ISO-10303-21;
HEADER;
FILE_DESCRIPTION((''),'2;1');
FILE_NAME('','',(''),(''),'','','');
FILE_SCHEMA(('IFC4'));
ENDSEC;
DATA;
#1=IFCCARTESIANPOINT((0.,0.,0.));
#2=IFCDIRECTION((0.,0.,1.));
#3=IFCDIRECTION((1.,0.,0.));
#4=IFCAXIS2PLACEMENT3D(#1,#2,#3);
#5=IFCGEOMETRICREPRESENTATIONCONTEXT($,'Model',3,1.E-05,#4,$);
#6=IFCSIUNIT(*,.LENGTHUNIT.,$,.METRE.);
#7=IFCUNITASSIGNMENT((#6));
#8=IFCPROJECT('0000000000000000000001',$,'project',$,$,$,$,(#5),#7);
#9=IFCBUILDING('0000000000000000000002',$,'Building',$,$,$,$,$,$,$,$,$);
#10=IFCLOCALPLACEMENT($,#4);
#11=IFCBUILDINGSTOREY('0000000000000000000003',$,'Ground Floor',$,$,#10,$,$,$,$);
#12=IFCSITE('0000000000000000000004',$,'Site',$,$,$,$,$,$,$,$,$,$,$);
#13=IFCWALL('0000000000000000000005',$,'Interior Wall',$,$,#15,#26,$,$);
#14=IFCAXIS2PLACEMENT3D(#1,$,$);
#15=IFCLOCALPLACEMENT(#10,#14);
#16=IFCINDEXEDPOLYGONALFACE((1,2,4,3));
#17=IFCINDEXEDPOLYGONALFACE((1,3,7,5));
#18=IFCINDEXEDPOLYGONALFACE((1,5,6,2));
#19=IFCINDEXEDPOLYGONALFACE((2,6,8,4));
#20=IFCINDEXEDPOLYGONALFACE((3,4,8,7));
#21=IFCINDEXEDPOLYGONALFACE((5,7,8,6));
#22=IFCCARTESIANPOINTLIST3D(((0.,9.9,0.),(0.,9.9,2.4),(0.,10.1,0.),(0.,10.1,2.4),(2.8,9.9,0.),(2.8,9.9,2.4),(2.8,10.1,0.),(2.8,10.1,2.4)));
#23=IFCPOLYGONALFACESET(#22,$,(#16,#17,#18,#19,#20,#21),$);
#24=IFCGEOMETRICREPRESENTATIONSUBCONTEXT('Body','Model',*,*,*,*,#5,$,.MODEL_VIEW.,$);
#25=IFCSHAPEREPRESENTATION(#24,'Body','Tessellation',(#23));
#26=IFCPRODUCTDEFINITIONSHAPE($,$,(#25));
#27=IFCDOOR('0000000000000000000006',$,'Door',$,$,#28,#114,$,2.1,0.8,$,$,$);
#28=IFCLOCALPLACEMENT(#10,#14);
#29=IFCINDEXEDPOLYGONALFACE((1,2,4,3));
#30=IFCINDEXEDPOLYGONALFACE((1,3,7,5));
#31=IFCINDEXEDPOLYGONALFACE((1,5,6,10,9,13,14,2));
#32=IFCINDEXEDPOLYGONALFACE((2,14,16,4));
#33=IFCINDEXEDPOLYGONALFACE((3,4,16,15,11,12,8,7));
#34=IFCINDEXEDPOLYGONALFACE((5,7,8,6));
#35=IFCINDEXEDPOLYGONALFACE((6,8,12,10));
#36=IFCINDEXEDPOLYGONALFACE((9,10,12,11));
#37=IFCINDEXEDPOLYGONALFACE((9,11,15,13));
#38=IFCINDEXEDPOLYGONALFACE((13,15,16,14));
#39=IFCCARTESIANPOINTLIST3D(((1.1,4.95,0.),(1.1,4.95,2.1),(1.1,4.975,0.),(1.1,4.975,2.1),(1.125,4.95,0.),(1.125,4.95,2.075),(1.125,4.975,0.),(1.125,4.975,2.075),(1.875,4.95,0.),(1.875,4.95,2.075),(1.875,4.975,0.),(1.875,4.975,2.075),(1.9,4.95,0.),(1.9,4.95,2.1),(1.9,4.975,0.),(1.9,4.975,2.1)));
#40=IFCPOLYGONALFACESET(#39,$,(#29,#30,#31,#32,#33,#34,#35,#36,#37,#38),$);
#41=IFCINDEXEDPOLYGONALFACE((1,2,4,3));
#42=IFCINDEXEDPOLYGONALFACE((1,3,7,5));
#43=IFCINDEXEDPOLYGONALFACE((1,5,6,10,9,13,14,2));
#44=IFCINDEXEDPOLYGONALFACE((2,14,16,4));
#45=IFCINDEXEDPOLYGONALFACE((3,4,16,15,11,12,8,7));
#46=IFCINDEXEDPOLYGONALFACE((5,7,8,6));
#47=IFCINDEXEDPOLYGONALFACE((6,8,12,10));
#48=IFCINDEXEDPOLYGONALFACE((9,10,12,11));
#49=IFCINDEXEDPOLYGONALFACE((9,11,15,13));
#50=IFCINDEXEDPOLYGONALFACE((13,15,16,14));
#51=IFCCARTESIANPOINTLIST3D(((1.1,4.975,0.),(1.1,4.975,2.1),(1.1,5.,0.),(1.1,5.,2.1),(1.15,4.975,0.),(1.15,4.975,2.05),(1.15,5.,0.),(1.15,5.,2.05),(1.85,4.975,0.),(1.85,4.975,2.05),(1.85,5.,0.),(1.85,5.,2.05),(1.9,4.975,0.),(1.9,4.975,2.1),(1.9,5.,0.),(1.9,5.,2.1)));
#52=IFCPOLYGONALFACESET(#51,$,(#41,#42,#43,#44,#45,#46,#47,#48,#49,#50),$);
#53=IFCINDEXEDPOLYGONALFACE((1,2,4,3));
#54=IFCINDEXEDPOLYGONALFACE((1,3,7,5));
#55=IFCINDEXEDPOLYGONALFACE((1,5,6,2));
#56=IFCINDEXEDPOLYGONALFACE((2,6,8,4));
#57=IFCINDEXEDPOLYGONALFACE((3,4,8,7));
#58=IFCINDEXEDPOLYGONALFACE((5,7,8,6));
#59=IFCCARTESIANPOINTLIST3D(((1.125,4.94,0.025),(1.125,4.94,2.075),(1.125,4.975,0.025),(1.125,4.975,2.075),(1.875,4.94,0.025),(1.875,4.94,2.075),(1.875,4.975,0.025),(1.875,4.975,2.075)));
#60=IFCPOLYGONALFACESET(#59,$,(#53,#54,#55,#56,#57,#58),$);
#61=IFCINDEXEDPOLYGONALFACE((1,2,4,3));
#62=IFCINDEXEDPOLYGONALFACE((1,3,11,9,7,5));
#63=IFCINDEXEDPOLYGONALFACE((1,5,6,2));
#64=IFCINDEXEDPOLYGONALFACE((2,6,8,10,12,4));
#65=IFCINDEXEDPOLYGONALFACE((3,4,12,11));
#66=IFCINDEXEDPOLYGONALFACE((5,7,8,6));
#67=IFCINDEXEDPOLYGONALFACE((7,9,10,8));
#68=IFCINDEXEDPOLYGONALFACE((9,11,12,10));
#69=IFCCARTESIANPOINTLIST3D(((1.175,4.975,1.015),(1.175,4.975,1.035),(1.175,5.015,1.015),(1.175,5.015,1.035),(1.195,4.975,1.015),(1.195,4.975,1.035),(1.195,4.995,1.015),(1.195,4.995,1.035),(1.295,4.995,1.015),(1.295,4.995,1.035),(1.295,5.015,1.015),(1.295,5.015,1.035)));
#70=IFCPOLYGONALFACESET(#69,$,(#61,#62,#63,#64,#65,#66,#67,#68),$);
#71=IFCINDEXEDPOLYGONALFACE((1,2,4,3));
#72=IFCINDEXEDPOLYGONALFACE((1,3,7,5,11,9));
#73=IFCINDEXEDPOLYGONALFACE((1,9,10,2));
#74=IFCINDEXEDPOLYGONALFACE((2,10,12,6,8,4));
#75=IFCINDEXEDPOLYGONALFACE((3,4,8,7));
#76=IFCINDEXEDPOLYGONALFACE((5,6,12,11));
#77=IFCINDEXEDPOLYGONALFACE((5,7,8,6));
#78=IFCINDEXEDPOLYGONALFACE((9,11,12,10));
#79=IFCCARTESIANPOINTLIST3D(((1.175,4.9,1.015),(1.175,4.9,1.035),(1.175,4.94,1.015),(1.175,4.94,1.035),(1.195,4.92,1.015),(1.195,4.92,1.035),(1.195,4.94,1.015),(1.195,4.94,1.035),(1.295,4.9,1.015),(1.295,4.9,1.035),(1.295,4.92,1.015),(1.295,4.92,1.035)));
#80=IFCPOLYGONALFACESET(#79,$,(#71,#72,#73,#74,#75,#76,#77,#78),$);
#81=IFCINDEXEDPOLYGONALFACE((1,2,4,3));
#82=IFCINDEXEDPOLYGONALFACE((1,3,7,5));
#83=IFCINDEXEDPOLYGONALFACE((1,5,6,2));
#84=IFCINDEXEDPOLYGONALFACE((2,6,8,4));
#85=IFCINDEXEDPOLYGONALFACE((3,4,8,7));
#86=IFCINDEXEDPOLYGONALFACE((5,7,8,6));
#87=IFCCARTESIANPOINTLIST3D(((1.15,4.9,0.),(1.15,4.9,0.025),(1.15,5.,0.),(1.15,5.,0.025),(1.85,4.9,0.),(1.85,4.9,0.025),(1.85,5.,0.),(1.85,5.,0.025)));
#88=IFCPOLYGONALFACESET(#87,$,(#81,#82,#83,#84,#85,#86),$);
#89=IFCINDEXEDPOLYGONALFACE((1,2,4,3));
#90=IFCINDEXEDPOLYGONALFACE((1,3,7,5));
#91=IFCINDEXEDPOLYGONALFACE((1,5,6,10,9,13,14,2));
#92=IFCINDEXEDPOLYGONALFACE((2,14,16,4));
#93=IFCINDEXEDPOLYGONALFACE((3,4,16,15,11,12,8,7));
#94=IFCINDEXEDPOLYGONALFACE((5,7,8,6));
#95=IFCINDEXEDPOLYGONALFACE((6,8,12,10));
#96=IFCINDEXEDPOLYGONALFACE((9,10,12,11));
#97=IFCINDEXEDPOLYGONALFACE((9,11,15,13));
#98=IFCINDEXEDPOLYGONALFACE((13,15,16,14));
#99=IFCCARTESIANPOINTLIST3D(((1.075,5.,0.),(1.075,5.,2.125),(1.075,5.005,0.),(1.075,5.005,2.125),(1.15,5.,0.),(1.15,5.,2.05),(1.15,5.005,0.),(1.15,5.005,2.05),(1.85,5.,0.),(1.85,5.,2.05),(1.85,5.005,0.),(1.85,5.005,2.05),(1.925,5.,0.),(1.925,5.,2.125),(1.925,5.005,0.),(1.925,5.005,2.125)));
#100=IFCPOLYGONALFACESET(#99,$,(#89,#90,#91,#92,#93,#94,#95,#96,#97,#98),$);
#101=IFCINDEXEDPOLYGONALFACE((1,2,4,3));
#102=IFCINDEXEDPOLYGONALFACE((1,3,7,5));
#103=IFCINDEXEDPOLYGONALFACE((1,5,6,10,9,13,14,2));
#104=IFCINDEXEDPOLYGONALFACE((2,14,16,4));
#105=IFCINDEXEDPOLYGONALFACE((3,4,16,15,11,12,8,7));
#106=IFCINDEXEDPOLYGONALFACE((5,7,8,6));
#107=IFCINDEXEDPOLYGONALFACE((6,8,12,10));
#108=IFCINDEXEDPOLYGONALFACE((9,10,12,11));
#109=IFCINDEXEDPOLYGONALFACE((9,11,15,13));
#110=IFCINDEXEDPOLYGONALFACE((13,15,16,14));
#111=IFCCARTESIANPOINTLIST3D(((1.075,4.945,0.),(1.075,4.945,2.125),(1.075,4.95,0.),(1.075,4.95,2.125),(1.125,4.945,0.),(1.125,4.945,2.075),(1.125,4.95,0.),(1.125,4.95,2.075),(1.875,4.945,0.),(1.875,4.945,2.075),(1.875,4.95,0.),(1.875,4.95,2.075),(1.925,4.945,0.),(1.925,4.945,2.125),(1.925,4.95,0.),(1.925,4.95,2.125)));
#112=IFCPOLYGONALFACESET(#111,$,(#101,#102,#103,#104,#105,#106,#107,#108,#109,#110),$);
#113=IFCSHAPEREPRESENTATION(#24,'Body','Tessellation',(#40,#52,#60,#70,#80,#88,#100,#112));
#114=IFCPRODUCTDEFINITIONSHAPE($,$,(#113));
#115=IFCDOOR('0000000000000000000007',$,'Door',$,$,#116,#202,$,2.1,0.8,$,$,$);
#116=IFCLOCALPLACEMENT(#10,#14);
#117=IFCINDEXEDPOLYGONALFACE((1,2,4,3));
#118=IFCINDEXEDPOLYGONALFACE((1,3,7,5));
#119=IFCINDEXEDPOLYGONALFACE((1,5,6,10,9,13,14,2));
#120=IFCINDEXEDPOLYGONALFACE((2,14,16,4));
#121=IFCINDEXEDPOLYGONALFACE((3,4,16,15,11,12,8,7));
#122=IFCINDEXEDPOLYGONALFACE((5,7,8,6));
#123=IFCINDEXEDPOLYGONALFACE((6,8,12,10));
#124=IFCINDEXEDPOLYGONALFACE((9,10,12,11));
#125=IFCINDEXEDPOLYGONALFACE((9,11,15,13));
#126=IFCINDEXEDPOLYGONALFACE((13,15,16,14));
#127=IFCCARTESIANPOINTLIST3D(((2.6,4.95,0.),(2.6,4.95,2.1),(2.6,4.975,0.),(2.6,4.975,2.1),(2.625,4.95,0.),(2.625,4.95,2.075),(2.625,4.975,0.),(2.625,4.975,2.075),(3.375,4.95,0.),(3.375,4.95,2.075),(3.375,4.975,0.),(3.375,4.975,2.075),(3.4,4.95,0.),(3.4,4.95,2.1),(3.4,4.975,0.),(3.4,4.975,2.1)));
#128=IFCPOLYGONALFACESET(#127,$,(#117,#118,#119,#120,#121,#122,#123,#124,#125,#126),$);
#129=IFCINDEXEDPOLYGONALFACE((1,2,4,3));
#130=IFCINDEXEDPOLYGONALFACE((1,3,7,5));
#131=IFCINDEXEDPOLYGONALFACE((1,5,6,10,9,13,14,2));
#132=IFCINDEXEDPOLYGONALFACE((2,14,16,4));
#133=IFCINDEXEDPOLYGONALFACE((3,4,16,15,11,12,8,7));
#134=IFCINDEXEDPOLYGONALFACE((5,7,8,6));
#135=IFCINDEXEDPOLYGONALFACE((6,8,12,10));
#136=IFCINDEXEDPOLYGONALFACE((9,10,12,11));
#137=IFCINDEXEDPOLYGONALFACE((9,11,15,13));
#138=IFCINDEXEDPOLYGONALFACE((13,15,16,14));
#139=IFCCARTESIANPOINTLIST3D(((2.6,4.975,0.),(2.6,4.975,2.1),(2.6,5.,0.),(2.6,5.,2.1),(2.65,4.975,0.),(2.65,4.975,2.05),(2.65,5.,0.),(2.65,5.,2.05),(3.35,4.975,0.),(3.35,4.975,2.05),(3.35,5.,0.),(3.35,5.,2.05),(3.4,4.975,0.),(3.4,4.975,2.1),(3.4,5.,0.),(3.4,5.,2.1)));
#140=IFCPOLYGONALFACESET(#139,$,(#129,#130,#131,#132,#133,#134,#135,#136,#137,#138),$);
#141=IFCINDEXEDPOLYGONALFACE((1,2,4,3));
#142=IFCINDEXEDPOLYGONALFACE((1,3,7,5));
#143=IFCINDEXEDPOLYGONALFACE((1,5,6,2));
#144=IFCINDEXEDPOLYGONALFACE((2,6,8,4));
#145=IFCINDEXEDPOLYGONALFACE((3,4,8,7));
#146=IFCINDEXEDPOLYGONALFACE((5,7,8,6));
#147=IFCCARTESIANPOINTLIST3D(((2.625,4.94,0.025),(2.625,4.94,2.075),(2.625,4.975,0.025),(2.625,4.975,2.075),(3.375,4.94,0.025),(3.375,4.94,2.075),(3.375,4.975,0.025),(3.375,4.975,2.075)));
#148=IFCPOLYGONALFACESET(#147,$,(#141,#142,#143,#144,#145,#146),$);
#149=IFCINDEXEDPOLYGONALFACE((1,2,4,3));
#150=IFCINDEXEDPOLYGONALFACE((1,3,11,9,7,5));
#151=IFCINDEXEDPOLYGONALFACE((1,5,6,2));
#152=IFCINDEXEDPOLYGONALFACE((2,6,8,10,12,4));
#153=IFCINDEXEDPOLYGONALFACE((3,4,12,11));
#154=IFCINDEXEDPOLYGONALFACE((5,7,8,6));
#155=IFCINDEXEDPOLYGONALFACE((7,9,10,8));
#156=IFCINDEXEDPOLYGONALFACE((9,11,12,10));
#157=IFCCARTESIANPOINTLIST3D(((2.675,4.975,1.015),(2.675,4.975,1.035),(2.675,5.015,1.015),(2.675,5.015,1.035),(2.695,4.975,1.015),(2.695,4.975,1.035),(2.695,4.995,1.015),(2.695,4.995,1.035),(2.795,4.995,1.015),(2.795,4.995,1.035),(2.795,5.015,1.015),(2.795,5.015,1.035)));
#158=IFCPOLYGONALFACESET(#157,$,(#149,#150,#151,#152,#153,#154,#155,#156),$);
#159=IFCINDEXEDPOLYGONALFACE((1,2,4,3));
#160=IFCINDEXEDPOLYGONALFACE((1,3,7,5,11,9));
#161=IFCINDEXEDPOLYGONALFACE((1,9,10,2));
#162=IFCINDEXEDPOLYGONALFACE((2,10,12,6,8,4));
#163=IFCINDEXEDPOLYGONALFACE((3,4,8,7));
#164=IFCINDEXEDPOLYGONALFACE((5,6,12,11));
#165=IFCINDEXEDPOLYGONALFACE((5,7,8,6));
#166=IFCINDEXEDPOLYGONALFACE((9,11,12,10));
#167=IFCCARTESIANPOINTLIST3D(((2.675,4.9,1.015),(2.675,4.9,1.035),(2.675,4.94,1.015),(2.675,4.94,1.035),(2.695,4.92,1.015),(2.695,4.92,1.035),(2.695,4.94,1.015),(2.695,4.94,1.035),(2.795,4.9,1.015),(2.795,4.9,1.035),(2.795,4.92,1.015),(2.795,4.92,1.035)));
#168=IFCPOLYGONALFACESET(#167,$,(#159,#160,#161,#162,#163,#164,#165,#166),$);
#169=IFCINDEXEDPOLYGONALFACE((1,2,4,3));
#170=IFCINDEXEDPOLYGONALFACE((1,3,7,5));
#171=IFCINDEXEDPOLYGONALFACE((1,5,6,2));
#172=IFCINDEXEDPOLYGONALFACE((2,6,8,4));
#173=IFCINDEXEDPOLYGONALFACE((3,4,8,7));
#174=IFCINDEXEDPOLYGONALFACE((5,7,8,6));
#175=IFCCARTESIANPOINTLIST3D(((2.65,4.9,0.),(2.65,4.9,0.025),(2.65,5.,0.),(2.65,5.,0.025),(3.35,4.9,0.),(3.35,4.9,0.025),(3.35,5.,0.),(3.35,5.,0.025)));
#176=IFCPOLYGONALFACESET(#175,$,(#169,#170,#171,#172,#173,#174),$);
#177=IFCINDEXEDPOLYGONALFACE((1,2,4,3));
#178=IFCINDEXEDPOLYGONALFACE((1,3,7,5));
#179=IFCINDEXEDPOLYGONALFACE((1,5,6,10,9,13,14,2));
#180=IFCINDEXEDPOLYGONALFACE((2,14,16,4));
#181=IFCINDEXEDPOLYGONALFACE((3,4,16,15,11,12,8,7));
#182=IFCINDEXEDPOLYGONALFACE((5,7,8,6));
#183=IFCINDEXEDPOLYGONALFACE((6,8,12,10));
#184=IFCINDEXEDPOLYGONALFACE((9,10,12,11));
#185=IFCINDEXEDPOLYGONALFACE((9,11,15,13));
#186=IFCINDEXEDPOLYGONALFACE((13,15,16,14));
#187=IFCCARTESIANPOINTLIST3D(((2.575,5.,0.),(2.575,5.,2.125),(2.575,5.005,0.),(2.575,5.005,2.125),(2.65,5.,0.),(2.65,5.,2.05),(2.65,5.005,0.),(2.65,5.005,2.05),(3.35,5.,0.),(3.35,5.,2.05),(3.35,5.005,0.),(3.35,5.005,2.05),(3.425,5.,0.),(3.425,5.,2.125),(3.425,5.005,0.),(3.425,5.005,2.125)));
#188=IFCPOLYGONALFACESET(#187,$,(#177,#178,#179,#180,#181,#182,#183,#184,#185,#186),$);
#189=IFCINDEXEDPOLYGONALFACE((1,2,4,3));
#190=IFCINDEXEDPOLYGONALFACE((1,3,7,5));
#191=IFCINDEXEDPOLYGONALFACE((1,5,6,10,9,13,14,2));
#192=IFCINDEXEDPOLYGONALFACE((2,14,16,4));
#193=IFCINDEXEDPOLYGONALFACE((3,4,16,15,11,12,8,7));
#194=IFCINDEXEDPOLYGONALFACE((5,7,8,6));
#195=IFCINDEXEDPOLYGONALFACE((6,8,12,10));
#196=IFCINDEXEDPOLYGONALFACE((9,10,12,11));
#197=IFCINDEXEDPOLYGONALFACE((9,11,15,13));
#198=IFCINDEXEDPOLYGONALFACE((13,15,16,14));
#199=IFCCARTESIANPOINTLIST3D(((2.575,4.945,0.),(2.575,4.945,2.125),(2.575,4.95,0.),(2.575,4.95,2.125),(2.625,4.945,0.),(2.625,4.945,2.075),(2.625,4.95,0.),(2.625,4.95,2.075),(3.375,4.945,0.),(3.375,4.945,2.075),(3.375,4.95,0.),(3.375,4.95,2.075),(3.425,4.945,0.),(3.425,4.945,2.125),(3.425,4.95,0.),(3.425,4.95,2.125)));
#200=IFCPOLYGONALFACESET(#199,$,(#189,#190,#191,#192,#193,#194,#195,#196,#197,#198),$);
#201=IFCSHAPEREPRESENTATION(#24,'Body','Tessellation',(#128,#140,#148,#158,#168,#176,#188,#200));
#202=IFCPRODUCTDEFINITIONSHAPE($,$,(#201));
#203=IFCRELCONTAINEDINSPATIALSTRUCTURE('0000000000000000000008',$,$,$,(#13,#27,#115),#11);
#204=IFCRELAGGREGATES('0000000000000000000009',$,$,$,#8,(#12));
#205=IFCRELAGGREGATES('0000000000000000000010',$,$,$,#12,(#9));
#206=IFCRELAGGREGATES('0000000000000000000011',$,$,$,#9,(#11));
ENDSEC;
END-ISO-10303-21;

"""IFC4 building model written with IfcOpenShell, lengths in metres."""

from ifc_helpers import new_model, si_unit, frame, origin_with_axes, place, context, subcontext, project, spatial, line, indexed_curve, outline, extrude, element, save


model = new_model("IFC4")

# Units and contexts
model_context = context("Model", 3, precision=1e-05, world=origin_with_axes())
body_context = subcontext(model_context, "Body", "Model", "MODEL_VIEW")
ifc_project = project(units=[si_unit("LENGTHUNIT", "METRE")], contexts=[model_context])

# Site, building, storey
site = spatial("IfcSite", under=ifc_project, Name="Site")
building = spatial("IfcBuilding", under=site, Name="Building")
storey_placement = place(None, origin_with_axes())
storey = spatial("IfcBuildingStorey", under=building, at=storey_placement, Name="Ground Floor")

# Wall
for number, where, z_axis, x_axis, name in (
    (1, (2.8, 10.0, 0.0), (0.0, 0.0, 1.0), (-1.0, 0.0, 0.0), "Interior Wall"),
):
    element("IfcWall", number, at=place(storey_placement, frame(where, z_axis=z_axis, x_axis=x_axis)), inside=storey, Name=name, context=body_context, shape_type="SweptSolid", body=[
        extrude(outline(indexed_curve([(0.0, 0.0), (0.0, 0.2), (2.8, 0.2), (2.8, 0.0), (0.0, 0.0)], self_intersect=False)), frame((0.0, -0.1, 0.0), z_axis=(0.0, 0.0, 1.0), x_axis=(1.0, 0.0, 0.0)), (0.0, 0.0, 1.0), 2.4),
    ])

# Doors
door_1_placement = place(storey_placement, frame((1.9, 5.0, 0.0), z_axis=(0.0, 0.0, 1.0), x_axis=(-1.0, 0.0, 0.0)))
element("IfcDoor", 2, at=door_1_placement, inside=storey, Name="Door", OverallHeight=2.1, OverallWidth=0.8, context=body_context, shape_type="SweptSolid", body=[
    extrude(outline(indexed_curve([(0.0, 0.0), (0.0, 2.1), (0.8, 2.1), (0.8, 0.0), (0.775, 0.0), (0.775, 2.075), (0.025, 2.075), (0.025, 0.0)], segments=[line(1, 2, 3, 4, 5, 6, 7, 8, 1)])), frame((0.0, 0.025, 0.0), z_axis=(0.0, -1.0, 0.0), x_axis=(1.0, 0.0, 0.0)), (0.0, 0.0, -1.0), 0.025),
    extrude(outline(indexed_curve([(0.0, 0.0), (0.0, 2.1), (0.8, 2.1), (0.8, 0.0), (0.75, 0.0), (0.75, 2.05), (0.05, 2.05), (0.05, 0.0)], segments=[line(1, 2, 3, 4, 5, 6, 7, 8, 1)])), frame((0.0, 0.0, 0.0), z_axis=(0.0, -1.0, 0.0), x_axis=(1.0, 0.0, 0.0)), (0.0, 0.0, -1.0), 0.025),
    extrude(outline(indexed_curve([(0.0, 0.0), (0.75, 0.0), (0.75, 0.035), (0.0, 0.035)], segments=[line(1, 2, 3, 4, 1)])), frame((0.025, 0.025, 0.025), z_axis=(0.0, 0.0, 1.0), x_axis=(1.0, 0.0, 0.0)), (0.0, 0.0, 1.0), 2.05),
    extrude(outline(indexed_curve([(0.0, 0.0), (0.0, -0.04), (-0.12, -0.04), (-0.12, -0.02), (-0.02, -0.02), (-0.02, 0.0)], segments=[line(1, 2, 3, 4, 5, 6, 1)])), frame((0.725, 0.025, 1.015), z_axis=(0.0, 0.0, 1.0), x_axis=(1.0, 0.0, 0.0)), (0.0, 0.0, 1.0), 0.02),
    extrude(outline(indexed_curve([(0.0, 0.0), (0.0, 0.04), (-0.12, 0.04), (-0.12, 0.02), (-0.02, 0.02), (-0.02, 0.0)], segments=[line(1, 2, 3, 4, 5, 6, 1)])), frame((0.725, 0.06, 1.015), z_axis=(0.0, 0.0, 1.0), x_axis=(1.0, 0.0, 0.0)), (0.0, 0.0, 1.0), 0.02),
    extrude(outline(indexed_curve([(0.0, 0.0), (0.7, 0.0), (0.7, 0.1), (0.0, 0.1)], segments=[line(1, 2, 3, 4, 1)])), frame((0.05, 0.0, 0.0), z_axis=(0.0, 0.0, 1.0), x_axis=(1.0, 0.0, 0.0)), (0.0, 0.0, 1.0), 0.025),
    extrude(outline(indexed_curve([(0.0, 0.0), (0.0, 2.125), (0.85, 2.125), (0.85, 0.0), (0.775, 0.0), (0.775, 2.05), (0.075, 2.05), (0.075, 0.0)], segments=[line(1, 2, 3, 4, 5, 6, 7, 8, 1)])), frame((-0.025, -0.005, 0.0), z_axis=(0.0, -1.0, 0.0), x_axis=(1.0, 0.0, 0.0)), (0.0, 0.0, -1.0), 0.005),
    extrude(outline(indexed_curve([(0.0, 0.0), (0.0, 2.125), (0.85, 2.125), (0.85, 0.0), (0.8, 0.0), (0.8, 2.075), (0.05, 2.075), (0.05, 0.0)], segments=[line(1, 2, 3, 4, 5, 6, 7, 8, 1)])), frame((-0.025, 0.05, 0.0), z_axis=(0.0, -1.0, 0.0), x_axis=(1.0, 0.0, 0.0)), (0.0, 0.0, -1.0), 0.005),
])
door_2_placement = place(storey_placement, frame((3.4, 5.0, 0.0), z_axis=(0.0, 0.0, 1.0), x_axis=(-1.0, 0.0, 0.0)))
element("IfcDoor", 3, at=door_2_placement, inside=storey, Name="Door", OverallHeight=2.1, OverallWidth=0.8, context=body_context, shape_type="SweptSolid", body=[
    extrude(outline(indexed_curve([(0.0, 0.0), (0.0, 2.1), (0.8, 2.1), (0.8, 0.0), (0.775, 0.0), (0.775, 2.075), (0.025, 2.075), (0.025, 0.0)], segments=[line(1, 2, 3, 4, 5, 6, 7, 8, 1)])), frame((0.0, 0.025, 0.0), z_axis=(0.0, -1.0, 0.0), x_axis=(1.0, 0.0, 0.0)), (0.0, 0.0, -1.0), 0.025),
    extrude(outline(indexed_curve([(0.0, 0.0), (0.0, 2.1), (0.8, 2.1), (0.8, 0.0), (0.75, 0.0), (0.75, 2.05), (0.05, 2.05), (0.05, 0.0)], segments=[line(1, 2, 3, 4, 5, 6, 7, 8, 1)])), frame((0.0, 0.0, 0.0), z_axis=(0.0, -1.0, 0.0), x_axis=(1.0, 0.0, 0.0)), (0.0, 0.0, -1.0), 0.025),
    extrude(outline(indexed_curve([(0.0, 0.0), (0.75, 0.0), (0.75, 0.035), (0.0, 0.035)], segments=[line(1, 2, 3, 4, 1)])), frame((0.025, 0.025, 0.025), z_axis=(0.0, 0.0, 1.0), x_axis=(1.0, 0.0, 0.0)), (0.0, 0.0, 1.0), 2.05),
    extrude(outline(indexed_curve([(0.0, 0.0), (0.0, -0.04), (-0.12, -0.04), (-0.12, -0.02), (-0.02, -0.02), (-0.02, 0.0)], segments=[line(1, 2, 3, 4, 5, 6, 1)])), frame((0.725, 0.025, 1.015), z_axis=(0.0, 0.0, 1.0), x_axis=(1.0, 0.0, 0.0)), (0.0, 0.0, 1.0), 0.02),
    extrude(outline(indexed_curve([(0.0, 0.0), (0.0, 0.04), (-0.12, 0.04), (-0.12, 0.02), (-0.02, 0.02), (-0.02, 0.0)], segments=[line(1, 2, 3, 4, 5, 6, 1)])), frame((0.725, 0.06, 1.015), z_axis=(0.0, 0.0, 1.0), x_axis=(1.0, 0.0, 0.0)), (0.0, 0.0, 1.0), 0.02),
    extrude(outline(indexed_curve([(0.0, 0.0), (0.7, 0.0), (0.7, 0.1), (0.0, 0.1)], segments=[line(1, 2, 3, 4, 1)])), frame((0.05, 0.0, 0.0), z_axis=(0.0, 0.0, 1.0), x_axis=(1.0, 0.0, 0.0)), (0.0, 0.0, 1.0), 0.025),
    extrude(outline(indexed_curve([(0.0, 0.0), (0.0, 2.125), (0.85, 2.125), (0.85, 0.0), (0.775, 0.0), (0.775, 2.05), (0.075, 2.05), (0.075, 0.0)], segments=[line(1, 2, 3, 4, 5, 6, 7, 8, 1)])), frame((-0.025, -0.005, 0.0), z_axis=(0.0, -1.0, 0.0), x_axis=(1.0, 0.0, 0.0)), (0.0, 0.0, -1.0), 0.005),
    extrude(outline(indexed_curve([(0.0, 0.0), (0.0, 2.125), (0.85, 2.125), (0.85, 0.0), (0.8, 0.0), (0.8, 2.075), (0.05, 2.075), (0.05, 0.0)], segments=[line(1, 2, 3, 4, 5, 6, 7, 8, 1)])), frame((-0.025, 0.05, 0.0), z_axis=(0.0, -1.0, 0.0), x_axis=(1.0, 0.0, 0.0)), (0.0, 0.0, -1.0), 0.005),
])

save(model, "model.ifc")
